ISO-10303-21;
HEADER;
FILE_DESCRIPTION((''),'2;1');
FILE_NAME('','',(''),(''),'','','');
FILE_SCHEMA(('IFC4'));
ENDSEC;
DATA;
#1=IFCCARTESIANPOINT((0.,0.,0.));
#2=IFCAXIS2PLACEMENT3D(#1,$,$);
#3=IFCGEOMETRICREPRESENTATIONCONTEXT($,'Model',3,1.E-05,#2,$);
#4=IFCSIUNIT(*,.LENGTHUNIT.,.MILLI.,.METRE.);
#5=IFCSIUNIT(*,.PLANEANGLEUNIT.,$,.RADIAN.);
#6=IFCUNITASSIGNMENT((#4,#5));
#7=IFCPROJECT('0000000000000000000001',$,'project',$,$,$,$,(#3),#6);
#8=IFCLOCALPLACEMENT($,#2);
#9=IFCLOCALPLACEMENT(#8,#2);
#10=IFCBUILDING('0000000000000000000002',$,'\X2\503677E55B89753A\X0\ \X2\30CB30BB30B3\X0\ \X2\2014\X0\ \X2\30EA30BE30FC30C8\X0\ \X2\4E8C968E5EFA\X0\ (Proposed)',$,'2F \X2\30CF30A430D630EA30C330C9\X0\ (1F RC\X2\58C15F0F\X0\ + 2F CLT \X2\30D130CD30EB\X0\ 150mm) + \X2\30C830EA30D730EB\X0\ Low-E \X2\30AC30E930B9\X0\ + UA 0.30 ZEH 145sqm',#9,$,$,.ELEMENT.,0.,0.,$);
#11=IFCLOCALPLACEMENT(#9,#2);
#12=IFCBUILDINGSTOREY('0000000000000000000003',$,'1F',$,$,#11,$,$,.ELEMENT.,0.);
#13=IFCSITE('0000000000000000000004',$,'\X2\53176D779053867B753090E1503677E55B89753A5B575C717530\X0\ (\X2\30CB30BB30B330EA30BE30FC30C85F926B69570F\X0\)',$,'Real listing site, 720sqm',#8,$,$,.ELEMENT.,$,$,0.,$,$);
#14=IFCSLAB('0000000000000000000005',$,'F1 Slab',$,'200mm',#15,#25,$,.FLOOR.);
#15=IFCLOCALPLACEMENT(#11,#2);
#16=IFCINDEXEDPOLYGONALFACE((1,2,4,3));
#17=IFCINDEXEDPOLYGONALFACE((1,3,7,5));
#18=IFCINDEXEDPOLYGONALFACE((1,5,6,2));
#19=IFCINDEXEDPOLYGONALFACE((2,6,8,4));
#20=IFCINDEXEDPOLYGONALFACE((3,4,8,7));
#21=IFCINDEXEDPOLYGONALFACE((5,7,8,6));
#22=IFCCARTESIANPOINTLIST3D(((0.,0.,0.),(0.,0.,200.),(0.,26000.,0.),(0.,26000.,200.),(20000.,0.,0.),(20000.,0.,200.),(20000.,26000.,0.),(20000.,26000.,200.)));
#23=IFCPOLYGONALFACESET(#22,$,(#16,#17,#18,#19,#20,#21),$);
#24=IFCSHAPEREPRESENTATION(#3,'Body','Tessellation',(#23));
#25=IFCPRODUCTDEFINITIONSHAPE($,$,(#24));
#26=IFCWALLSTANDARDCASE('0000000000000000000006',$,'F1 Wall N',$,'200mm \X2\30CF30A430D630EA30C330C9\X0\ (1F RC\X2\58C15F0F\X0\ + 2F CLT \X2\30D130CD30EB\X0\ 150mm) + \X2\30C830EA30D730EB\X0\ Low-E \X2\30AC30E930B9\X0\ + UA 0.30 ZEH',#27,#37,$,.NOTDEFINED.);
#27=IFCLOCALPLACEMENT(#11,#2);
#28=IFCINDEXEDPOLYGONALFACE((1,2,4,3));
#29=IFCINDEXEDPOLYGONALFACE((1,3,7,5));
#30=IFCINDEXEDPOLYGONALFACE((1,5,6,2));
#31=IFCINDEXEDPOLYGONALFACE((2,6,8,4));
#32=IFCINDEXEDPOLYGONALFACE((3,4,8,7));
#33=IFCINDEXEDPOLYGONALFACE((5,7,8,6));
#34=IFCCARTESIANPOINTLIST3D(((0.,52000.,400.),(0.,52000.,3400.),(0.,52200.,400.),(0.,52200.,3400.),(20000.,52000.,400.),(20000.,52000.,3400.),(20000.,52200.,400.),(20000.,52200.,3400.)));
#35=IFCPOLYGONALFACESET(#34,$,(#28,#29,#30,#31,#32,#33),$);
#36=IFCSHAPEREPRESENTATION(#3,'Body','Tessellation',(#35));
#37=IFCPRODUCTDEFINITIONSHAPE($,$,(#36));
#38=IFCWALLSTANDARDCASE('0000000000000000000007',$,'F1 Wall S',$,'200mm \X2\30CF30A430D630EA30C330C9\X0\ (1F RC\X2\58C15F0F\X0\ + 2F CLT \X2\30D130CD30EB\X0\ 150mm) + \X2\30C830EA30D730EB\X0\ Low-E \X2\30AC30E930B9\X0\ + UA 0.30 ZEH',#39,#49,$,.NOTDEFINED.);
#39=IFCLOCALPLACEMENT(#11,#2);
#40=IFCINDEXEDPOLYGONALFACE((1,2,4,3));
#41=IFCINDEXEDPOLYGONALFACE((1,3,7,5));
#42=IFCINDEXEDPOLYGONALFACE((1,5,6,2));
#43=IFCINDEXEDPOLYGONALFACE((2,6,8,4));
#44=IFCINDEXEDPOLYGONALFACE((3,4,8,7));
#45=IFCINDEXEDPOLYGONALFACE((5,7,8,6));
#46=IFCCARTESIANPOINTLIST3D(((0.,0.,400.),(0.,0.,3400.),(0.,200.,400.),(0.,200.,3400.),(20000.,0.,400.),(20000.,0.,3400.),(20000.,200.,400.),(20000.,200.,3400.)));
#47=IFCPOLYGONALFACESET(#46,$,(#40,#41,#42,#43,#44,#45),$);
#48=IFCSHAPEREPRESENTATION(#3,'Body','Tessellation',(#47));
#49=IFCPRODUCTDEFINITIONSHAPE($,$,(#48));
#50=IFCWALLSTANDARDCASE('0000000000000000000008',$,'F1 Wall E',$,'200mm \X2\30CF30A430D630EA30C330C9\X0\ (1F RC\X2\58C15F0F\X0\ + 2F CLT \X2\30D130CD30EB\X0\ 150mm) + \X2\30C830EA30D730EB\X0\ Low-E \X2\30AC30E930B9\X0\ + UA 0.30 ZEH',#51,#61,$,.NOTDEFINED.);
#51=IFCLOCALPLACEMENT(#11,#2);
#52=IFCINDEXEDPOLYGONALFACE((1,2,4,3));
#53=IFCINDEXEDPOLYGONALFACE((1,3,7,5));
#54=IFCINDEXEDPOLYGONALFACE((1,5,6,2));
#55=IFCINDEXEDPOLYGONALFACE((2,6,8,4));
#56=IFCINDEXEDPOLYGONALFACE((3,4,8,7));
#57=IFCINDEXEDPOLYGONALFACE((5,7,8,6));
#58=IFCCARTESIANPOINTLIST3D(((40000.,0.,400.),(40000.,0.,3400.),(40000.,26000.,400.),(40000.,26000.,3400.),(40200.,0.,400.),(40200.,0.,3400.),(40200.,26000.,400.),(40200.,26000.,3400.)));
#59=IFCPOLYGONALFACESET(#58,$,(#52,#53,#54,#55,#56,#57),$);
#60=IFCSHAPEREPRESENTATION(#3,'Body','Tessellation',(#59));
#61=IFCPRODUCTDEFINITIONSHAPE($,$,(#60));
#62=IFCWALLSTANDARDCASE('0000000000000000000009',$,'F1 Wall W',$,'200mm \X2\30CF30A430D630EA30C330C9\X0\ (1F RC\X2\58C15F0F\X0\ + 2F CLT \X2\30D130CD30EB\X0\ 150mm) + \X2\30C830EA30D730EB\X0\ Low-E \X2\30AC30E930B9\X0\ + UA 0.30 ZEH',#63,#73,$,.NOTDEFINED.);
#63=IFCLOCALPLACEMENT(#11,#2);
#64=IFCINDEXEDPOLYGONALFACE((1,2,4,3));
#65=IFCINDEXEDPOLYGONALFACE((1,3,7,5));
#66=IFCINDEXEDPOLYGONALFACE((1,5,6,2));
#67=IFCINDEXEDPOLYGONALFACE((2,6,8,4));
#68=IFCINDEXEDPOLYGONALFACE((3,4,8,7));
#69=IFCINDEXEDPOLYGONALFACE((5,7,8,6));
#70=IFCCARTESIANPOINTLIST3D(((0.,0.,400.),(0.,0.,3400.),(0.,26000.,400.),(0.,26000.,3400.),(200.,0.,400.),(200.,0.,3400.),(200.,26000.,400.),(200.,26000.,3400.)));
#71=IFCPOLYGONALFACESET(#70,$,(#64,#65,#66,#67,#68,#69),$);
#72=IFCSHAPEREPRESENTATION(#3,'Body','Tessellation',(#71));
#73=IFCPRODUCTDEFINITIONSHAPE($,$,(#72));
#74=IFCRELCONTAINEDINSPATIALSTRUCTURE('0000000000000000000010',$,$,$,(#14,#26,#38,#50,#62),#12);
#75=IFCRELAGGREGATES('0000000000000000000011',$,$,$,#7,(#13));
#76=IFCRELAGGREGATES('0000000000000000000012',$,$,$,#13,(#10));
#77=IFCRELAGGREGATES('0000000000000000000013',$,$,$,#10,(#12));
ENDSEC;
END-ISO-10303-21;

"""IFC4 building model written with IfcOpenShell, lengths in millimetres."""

from ifc_helpers import new_model, si_unit, frame, frame_2d, origin, place, context, project, spatial, rectangle, extrude, element, save


model = new_model("IFC4")

# Units and contexts
model_context = context("Model", 3, precision=1e-05, world=origin())
ifc_project = project(units=[si_unit("LENGTHUNIT", "METRE", prefix="MILLI"), si_unit("PLANEANGLEUNIT", "RADIAN")], contexts=[model_context])

# Site, building, storey
site_placement = place(None, origin())
site = spatial("IfcSite", under=ifc_project, at=site_placement, Name="北海道虻田郡倶知安町字山田 (ニセコリゾート徒歩圏)", ObjectType="Real listing site, 720sqm", CompositionType="ELEMENT", RefElevation=0.0)
building_placement = place(site_placement, origin())
building = spatial("IfcBuilding", under=site, at=building_placement, Name="倶知安町 ニセコ — リゾート 二階建 (Proposed)", ObjectType="2F ハイブリッド (1F RC壁式 + 2F CLT パネル 150mm) + トリプル Low-E ガラス + UA 0.30 ZEH 145sqm", CompositionType="ELEMENT", ElevationOfRefHeight=0.0, ElevationOfTerrain=0.0)
storey_placement = place(building_placement, origin())
storey = spatial("IfcBuildingStorey", under=building, at=storey_placement, Name="1F", CompositionType="ELEMENT", Elevation=0.0)

# Slab
slab_placement = place(storey_placement, origin())
element("IfcSlab", 1, at=slab_placement, inside=storey, Name="F1 Slab", ObjectType="200mm", PredefinedType="FLOOR", context=model_context, shape_type="SweptSolid", body=[
    extrude(rectangle(XDim=20000.0, YDim=26000.0, at=frame_2d((10000.0, 13000.0))), origin(), (0.0, 0.0, 1.0), 200.0),
])

# Walls
wall_1_placement = place(storey_placement, frame((0.0, 26000.0, 200.0)))
element("IfcWallStandardCase", 2, at=wall_1_placement, inside=storey, Name="F1 Wall N", ObjectType="200mm ハイブリッド (1F RC壁式 + 2F CLT パネル 150mm) + トリプル Low-E ガラス + UA 0.30 ZEH", PredefinedType="NOTDEFINED", context=model_context, shape_type="SweptSolid", body=[
    extrude(rectangle(XDim=20000.0, YDim=200.0, at=frame_2d((10000.0, 100.0))), frame((0.0, 26000.0, 200.0)), (0.0, 0.0, 1.0), 3000.0),
])
wall_2_placement = place(storey_placement, frame((0.0, 0.0, 200.0)))
element("IfcWallStandardCase", 3, at=wall_2_placement, inside=storey, Name="F1 Wall S", ObjectType="200mm ハイブリッド (1F RC壁式 + 2F CLT パネル 150mm) + トリプル Low-E ガラス + UA 0.30 ZEH", PredefinedType="NOTDEFINED", context=model_context, shape_type="SweptSolid", body=[
    extrude(rectangle(XDim=20000.0, YDim=200.0, at=frame_2d((10000.0, 100.0))), frame((0.0, 0.0, 200.0)), (0.0, 0.0, 1.0), 3000.0),
])
wall_3_placement = place(storey_placement, frame((20000.0, 0.0, 200.0)))
element("IfcWallStandardCase", 4, at=wall_3_placement, inside=storey, Name="F1 Wall E", ObjectType="200mm ハイブリッド (1F RC壁式 + 2F CLT パネル 150mm) + トリプル Low-E ガラス + UA 0.30 ZEH", PredefinedType="NOTDEFINED", context=model_context, shape_type="SweptSolid", body=[
    extrude(rectangle(XDim=200.0, YDim=26000.0, at=frame_2d((100.0, 13000.0))), frame((20000.0, 0.0, 200.0)), (0.0, 0.0, 1.0), 3000.0),
])
wall_4_placement = place(storey_placement, frame((0.0, 0.0, 200.0)))
element("IfcWallStandardCase", 5, at=wall_4_placement, inside=storey, Name="F1 Wall W", ObjectType="200mm ハイブリッド (1F RC壁式 + 2F CLT パネル 150mm) + トリプル Low-E ガラス + UA 0.30 ZEH", PredefinedType="NOTDEFINED", context=model_context, shape_type="SweptSolid", body=[
    extrude(rectangle(XDim=200.0, YDim=26000.0, at=frame_2d((100.0, 13000.0))), frame((0.0, 0.0, 200.0)), (0.0, 0.0, 1.0), 3000.0),
])

save(model, "model.ifc")
